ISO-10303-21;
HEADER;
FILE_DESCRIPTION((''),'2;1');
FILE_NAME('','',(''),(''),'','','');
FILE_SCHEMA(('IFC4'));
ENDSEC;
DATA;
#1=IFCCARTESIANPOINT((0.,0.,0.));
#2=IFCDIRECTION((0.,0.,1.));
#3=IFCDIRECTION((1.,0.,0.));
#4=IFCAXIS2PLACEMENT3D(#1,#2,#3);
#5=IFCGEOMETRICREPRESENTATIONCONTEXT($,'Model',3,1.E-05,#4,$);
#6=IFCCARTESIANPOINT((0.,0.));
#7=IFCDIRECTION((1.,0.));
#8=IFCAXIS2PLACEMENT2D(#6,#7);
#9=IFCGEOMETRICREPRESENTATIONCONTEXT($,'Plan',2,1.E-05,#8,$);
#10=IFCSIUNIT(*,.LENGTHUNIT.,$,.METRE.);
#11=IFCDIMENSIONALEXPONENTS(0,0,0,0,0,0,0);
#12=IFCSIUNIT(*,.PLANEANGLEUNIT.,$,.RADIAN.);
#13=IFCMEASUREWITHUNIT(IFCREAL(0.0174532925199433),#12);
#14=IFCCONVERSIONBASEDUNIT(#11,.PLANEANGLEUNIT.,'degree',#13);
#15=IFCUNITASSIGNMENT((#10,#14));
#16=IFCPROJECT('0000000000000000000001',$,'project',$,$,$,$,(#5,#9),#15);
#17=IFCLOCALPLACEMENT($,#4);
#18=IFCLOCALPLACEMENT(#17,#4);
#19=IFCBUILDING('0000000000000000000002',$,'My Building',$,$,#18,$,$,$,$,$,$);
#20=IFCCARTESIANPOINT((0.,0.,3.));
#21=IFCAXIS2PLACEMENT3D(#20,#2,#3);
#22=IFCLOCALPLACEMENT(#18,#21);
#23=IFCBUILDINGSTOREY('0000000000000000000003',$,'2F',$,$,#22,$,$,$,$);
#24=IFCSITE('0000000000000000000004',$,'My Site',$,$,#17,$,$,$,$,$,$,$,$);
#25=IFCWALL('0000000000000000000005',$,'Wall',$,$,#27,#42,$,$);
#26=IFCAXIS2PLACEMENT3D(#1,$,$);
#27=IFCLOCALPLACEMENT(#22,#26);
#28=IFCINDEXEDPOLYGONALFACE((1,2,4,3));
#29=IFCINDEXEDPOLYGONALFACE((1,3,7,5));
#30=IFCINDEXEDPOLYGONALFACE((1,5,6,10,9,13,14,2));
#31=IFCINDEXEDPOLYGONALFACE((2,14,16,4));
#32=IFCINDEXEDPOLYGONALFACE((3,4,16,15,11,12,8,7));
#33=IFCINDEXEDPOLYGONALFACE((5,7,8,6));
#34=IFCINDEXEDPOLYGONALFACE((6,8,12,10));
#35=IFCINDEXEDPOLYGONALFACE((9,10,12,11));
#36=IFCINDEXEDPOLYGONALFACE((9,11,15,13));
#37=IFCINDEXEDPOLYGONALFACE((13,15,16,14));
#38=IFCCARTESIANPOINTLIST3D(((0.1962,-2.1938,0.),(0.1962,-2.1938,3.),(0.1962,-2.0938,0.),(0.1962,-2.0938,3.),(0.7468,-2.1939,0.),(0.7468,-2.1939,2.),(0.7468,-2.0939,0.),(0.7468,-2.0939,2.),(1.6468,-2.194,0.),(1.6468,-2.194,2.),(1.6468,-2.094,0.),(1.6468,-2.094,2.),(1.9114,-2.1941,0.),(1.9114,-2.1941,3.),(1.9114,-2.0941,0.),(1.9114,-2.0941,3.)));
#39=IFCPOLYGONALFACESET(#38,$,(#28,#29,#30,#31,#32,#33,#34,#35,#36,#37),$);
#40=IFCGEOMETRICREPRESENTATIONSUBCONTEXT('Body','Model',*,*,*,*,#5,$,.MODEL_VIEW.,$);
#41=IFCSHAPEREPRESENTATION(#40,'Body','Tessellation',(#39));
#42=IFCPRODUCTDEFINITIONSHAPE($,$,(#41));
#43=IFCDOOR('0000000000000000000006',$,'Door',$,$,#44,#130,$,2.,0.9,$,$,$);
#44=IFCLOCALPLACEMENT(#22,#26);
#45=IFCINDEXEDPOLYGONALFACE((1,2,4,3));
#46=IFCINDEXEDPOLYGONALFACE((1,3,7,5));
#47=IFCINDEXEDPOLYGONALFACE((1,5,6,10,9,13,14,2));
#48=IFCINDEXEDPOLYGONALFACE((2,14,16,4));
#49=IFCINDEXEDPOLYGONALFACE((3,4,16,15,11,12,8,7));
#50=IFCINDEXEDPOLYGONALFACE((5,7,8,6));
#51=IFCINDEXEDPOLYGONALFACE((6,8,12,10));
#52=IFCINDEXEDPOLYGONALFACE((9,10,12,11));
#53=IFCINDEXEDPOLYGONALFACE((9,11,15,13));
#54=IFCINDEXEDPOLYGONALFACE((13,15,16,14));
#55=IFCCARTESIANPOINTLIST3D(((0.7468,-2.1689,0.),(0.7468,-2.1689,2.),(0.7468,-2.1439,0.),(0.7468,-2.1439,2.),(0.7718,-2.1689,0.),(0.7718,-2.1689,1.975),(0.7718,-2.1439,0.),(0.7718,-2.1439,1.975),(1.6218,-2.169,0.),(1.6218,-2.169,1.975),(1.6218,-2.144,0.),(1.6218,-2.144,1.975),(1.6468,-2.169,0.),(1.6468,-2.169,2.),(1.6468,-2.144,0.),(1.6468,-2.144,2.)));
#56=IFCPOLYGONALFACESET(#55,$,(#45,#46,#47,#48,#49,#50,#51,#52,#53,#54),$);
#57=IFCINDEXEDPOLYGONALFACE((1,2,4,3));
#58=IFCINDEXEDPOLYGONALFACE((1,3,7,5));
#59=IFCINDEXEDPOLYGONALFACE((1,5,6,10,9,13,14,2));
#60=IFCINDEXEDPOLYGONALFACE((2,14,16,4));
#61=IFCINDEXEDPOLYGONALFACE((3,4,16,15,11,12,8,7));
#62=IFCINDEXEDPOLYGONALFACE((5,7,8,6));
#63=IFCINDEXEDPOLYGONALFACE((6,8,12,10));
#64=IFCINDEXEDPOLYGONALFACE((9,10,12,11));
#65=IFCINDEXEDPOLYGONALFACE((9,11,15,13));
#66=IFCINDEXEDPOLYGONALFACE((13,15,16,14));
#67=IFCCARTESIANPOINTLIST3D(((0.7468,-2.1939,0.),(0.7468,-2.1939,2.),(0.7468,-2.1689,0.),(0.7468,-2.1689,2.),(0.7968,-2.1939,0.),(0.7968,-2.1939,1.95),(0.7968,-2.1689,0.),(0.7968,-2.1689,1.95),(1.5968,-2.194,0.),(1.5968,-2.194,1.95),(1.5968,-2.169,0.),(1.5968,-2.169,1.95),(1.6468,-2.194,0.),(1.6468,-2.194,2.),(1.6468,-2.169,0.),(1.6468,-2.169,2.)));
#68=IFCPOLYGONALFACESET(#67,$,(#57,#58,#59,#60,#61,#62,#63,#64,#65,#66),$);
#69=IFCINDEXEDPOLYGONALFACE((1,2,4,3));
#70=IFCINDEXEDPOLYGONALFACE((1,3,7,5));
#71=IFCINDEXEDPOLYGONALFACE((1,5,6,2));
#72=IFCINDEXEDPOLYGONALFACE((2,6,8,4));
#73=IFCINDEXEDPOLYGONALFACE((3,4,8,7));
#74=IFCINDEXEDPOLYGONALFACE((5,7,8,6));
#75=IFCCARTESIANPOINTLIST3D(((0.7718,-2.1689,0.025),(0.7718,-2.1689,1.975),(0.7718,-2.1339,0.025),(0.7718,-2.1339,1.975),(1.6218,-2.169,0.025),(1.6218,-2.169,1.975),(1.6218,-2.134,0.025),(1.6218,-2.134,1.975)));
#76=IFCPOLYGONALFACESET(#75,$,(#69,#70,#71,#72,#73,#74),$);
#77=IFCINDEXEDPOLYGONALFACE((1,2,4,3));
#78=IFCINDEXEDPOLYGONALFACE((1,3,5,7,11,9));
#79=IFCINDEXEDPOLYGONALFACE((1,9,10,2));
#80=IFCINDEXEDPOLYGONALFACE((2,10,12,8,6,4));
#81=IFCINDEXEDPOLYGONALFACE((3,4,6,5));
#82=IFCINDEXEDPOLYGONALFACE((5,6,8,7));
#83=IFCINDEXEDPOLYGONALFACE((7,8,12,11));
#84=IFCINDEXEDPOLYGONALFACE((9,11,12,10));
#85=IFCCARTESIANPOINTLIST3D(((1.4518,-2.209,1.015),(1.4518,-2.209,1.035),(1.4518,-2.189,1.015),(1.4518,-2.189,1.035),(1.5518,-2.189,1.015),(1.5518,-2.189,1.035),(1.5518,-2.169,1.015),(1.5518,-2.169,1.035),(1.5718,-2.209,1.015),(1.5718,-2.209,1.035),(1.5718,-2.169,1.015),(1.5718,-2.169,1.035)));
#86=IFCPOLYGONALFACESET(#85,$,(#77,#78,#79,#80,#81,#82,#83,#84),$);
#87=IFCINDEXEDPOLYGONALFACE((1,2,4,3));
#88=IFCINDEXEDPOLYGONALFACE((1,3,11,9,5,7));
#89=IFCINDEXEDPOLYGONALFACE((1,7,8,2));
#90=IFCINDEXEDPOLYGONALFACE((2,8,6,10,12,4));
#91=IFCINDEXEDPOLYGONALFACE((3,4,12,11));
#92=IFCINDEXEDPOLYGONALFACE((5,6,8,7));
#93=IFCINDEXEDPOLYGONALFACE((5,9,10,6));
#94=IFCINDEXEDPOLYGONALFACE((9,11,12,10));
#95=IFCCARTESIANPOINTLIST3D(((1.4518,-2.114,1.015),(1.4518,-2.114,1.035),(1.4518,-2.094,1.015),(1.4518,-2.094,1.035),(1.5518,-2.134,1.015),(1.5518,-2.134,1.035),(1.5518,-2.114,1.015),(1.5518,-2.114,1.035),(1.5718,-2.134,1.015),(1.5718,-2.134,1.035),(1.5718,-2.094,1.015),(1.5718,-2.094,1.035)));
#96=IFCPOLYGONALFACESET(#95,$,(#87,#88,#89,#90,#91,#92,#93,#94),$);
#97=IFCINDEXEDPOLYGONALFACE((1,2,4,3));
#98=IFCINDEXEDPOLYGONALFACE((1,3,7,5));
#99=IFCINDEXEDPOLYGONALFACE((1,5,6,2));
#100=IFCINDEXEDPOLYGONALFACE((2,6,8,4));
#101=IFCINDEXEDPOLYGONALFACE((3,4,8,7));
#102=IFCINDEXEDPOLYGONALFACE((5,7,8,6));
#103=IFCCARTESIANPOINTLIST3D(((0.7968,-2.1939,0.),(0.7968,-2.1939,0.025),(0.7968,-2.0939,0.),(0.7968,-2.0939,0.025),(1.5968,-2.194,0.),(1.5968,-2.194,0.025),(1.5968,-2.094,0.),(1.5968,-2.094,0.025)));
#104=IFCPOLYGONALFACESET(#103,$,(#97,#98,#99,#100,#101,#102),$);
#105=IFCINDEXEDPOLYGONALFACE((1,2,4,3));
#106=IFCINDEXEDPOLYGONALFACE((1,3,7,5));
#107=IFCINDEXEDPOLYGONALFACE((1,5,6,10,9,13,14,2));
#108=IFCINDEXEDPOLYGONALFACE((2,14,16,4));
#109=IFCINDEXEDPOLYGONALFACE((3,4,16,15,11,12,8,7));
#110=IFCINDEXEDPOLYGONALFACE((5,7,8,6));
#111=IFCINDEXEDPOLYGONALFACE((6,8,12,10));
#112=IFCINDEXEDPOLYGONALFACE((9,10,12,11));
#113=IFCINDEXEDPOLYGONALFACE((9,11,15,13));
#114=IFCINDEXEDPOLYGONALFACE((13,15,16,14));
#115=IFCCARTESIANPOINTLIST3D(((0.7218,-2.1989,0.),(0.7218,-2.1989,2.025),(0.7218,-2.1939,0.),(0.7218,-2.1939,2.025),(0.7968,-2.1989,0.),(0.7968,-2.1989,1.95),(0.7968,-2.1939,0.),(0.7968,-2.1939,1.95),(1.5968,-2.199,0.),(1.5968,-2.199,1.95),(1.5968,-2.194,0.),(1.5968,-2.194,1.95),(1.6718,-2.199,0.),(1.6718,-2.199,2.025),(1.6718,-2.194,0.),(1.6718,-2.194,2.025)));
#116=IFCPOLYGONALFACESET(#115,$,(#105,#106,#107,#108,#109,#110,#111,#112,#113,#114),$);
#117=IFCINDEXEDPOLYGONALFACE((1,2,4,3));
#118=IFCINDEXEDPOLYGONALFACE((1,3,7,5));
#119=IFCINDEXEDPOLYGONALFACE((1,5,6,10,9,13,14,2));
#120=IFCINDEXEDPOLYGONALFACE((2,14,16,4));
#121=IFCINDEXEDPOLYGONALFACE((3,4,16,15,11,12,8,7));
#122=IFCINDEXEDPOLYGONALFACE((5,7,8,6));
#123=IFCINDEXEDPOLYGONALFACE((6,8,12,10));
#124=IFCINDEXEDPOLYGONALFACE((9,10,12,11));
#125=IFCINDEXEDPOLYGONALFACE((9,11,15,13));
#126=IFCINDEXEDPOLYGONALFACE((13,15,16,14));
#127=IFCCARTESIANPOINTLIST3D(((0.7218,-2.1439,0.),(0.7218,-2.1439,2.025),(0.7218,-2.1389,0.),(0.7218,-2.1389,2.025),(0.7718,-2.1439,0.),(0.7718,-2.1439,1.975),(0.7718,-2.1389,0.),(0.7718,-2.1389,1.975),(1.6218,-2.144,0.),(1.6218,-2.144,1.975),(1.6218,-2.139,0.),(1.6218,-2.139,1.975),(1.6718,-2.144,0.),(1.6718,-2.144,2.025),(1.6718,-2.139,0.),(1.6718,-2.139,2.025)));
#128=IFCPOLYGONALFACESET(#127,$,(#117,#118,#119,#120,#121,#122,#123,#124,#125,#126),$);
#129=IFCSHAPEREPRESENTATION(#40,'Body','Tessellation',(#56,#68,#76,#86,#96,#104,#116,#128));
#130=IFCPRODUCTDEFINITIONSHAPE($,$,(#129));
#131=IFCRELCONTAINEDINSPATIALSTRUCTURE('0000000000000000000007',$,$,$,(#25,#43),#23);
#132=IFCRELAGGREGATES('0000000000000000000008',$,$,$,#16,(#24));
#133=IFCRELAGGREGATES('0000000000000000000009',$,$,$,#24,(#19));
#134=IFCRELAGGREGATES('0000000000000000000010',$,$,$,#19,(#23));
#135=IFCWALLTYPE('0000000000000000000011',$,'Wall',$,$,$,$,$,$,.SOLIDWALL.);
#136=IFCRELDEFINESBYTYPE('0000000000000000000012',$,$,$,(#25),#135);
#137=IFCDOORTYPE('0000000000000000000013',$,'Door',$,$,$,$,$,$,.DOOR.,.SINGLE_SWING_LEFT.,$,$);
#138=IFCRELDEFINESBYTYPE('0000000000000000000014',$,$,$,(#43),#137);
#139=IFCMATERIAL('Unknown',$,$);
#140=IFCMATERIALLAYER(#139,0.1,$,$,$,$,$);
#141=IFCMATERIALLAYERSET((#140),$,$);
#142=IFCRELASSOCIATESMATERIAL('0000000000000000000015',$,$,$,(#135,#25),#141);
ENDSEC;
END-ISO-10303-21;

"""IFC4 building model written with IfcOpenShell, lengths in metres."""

from ifc_helpers import new_model, entity, si_unit, converted_unit, frame, origin_with_axes, origin_2d_with_axis, place, context, subcontext, project, spatial, line, indexed_curve, outline, extrude, shape, source, transform, mapped, material, layer, layer_set, layer_usage, type_object, type_shapes, element, fill, save


model = new_model("IFC4")

# Units and contexts
model_context = context("Model", 3, precision=1e-05, world=origin_with_axes())
plan_context = context("Plan", 2, precision=1e-05, world=origin_2d_with_axis())
body_context_1 = subcontext(model_context, "Body", "Model", "MODEL_VIEW")
body_context_2 = subcontext(plan_context, "Body", "Plan", "PLAN_VIEW")
ifc_project = project(units=[si_unit("LENGTHUNIT", "METRE"), converted_unit("PLANEANGLEUNIT", "degree", entity("IfcReal", 0.0174532925199433), si_unit("PLANEANGLEUNIT", "RADIAN"), dimensions=[0, 0, 0, 0, 0, 0, 0])], contexts=[model_context, plan_context])

# Site, building, storey
site_placement = place(None, origin_with_axes())
site = spatial("IfcSite", under=ifc_project, at=site_placement, Name="My Site")
building_placement = place(site_placement, origin_with_axes())
building = spatial("IfcBuilding", under=site, at=building_placement, Name="My Building")
storey_placement = place(building_placement, frame((0.0, 0.0, 3.0), z_axis=(0.0, 0.0, 1.0), x_axis=(1.0, 0.0, 0.0)))
storey = spatial("IfcBuildingStorey", under=building, at=storey_placement, Name="2F")

# Shared definitions
ifc_material = material(Name="Unknown")

# Shared definitions
ifc_layer = layer(ifc_material, 0.1)
ifc_layer_set = layer_set([ifc_layer])
wall_type = type_object("IfcWallType", Name="Wall", PredefinedType="SOLIDWALL", material=ifc_layer_set)

# Wall, opening, door
ifc_layer_usage_1 = layer_usage(ifc_layer_set, "AXIS2", "POSITIVE", 0.0)
wall_1_placement = place(storey_placement, frame((0.1962, -2.1938, 0.0), z_axis=(0.0, 0.0, 1.0), x_axis=(1.0, -0.00013, 0.0)))
wall_1 = element("IfcWall", 1, at=wall_1_placement, inside=storey, type_object=wall_type, material=ifc_layer_usage_1, Name="Wall", context=body_context_1, shape_type="SweptSolid", body=[
    extrude(outline(indexed_curve([(0.0, 0.0), (0.0, 0.1), (1.7152, 0.1), (1.7152, 0.0)], segments=[line(1, 2, 3, 4, 1)])), origin_with_axes(), (0.0, 0.0, 1.0), 3.0),
])
shared_shape_1 = source(origin_with_axes(), body_context_1, "Body", "SweptSolid", [
    extrude(outline(indexed_curve([(0.0, 0.0), (0.9, 0.0), (0.9, 2.0), (0.0, 2.0)], segments=[line(1, 2, 3, 4, 1)])), frame((0.0, -0.6, 0.0), z_axis=(0.0, -1.0, 0.0), x_axis=(1.0, 0.0, 0.0)), (0.0, 0.0, -1.0), 1.2),
])
opening_1_placement = place(wall_1_placement, frame((0.5506, 0.0, 0.0), z_axis=(0.0, 0.0, 1.0), x_axis=(1.0, 0.0, 0.0)))
opening_1 = element("IfcOpeningElement", 2, at=opening_1_placement, cuts=wall_1, PredefinedType="OPENING", context=body_context_1, shape_type="MappedRepresentation", body=[
    mapped(shared_shape_1, transform((0.0, 0.0, 0.0), x_axis=(1.0, 0.0, 0.0), y_axis=(0.0, 1.0, 0.0), z_axis=(0.0, 0.0, 1.0), scale=1.0)),
])
door_type = type_object("IfcDoorType", Name="Door", OperationType="SINGLE_SWING_LEFT", PredefinedType="DOOR")
shared_shape_2 = source(origin_with_axes(), body_context_1, "Body", "SweptSolid", [
    extrude(outline(indexed_curve([(0.0, 0.0), (0.0, 2.0), (0.9, 2.0), (0.9, 0.0), (0.875, 0.0), (0.875, 1.975), (0.025, 1.975), (0.025, 0.0)], segments=[line(1, 2, 3, 4, 5, 6, 7, 8, 1)])), frame((0.0, 0.025, 0.0), z_axis=(0.0, -1.0, 0.0), x_axis=(1.0, 0.0, 0.0)), (0.0, 0.0, -1.0), 0.025),
    extrude(outline(indexed_curve([(0.0, 0.0), (0.0, 2.0), (0.9, 2.0), (0.9, 0.0), (0.85, 0.0), (0.85, 1.95), (0.05, 1.95), (0.05, 0.0)], segments=[line(1, 2, 3, 4, 5, 6, 7, 8, 1)])), frame((0.0, 0.0, 0.0), z_axis=(0.0, -1.0, 0.0), x_axis=(1.0, 0.0, 0.0)), (0.0, 0.0, -1.0), 0.025),
    extrude(outline(indexed_curve([(0.0, 0.0), (0.85, 0.0), (0.85, 0.035), (0.0, 0.035)], segments=[line(1, 2, 3, 4, 1)])), frame((0.025, 0.025, 0.025), z_axis=(0.0, 0.0, 1.0), x_axis=(1.0, 0.0, 0.0)), (0.0, 0.0, 1.0), 1.95),
    extrude(outline(indexed_curve([(0.0, 0.0), (0.0, -0.04), (-0.12, -0.04), (-0.12, -0.02), (-0.02, -0.02), (-0.02, 0.0)], segments=[line(1, 2, 3, 4, 5, 6, 1)])), frame((0.825, 0.025, 1.015), z_axis=(0.0, 0.0, 1.0), x_axis=(1.0, 0.0, 0.0)), (0.0, 0.0, 1.0), 0.02),
    extrude(outline(indexed_curve([(0.0, 0.0), (0.0, 0.04), (-0.12, 0.04), (-0.12, 0.02), (-0.02, 0.02), (-0.02, 0.0)], segments=[line(1, 2, 3, 4, 5, 6, 1)])), frame((0.825, 0.06, 1.015), z_axis=(0.0, 0.0, 1.0), x_axis=(1.0, 0.0, 0.0)), (0.0, 0.0, 1.0), 0.02),
    extrude(outline(indexed_curve([(0.0, 0.0), (0.8, 0.0), (0.8, 0.1), (0.0, 0.1)], segments=[line(1, 2, 3, 4, 1)])), frame((0.05, 0.0, 0.0), z_axis=(0.0, 0.0, 1.0), x_axis=(1.0, 0.0, 0.0)), (0.0, 0.0, 1.0), 0.025),
    extrude(outline(indexed_curve([(0.0, 0.0), (0.0, 2.025), (0.95, 2.025), (0.95, 0.0), (0.875, 0.0), (0.875, 1.95), (0.075, 1.95), (0.075, 0.0)], segments=[line(1, 2, 3, 4, 5, 6, 7, 8, 1)])), frame((-0.025, -0.005, 0.0), z_axis=(0.0, -1.0, 0.0), x_axis=(1.0, 0.0, 0.0)), (0.0, 0.0, -1.0), 0.005),
    extrude(outline(indexed_curve([(0.0, 0.0), (0.0, 2.025), (0.95, 2.025), (0.95, 0.0), (0.9, 0.0), (0.9, 1.975), (0.05, 1.975), (0.05, 0.0)], segments=[line(1, 2, 3, 4, 5, 6, 7, 8, 1)])), frame((-0.025, 0.05, 0.0), z_axis=(0.0, -1.0, 0.0), x_axis=(1.0, 0.0, 0.0)), (0.0, 0.0, -1.0), 0.005),
])
shared_shape_3 = source(origin_with_axes(), body_context_2, "Body", "Curve2D", [
    entity("IfcIndexedPolyCurve", entity("IfcCartesianPointList2D", [[0.0, 0.0], [0.0, 0.05], [0.025, 0.05], [0.025, 0.025], [0.05, 0.025], [0.05, 0.0]]), [entity("IfcLineIndex", [1, 2, 3, 4, 5, 6, 1])]),
    entity("IfcIndexedPolyCurve", entity("IfcCartesianPointList2D", [[0.9, 0.0], [0.9, 0.05], [0.875, 0.05], [0.875, 0.025], [0.85, 0.025], [0.85, 0.0]]), [entity("IfcLineIndex", [1, 2, 3, 4, 5, 6, 1])]),
    entity("IfcTrimmedCurve", entity("IfcEllipse", entity("IfcAxis2Placement2D", entity("IfcCartesianPoint", [0.06, 0.05]), entity("IfcDirection", [1.0, 0.0])), 0.815, 0.85), [entity("IfcCartesianPoint", [0.875, 0.05])], [entity("IfcCartesianPoint", [0.06, 0.9])], True, "CARTESIAN"),
    entity("IfcIndexedPolyCurve", entity("IfcCartesianPointList2D", [[0.025, 0.05], [0.06, 0.05], [0.06, 0.9], [0.025, 0.9]]), [entity("IfcLineIndex", [1, 2, 3, 4, 1])]),
])
type_shapes(door_type, [shared_shape_2, shared_shape_3])
door_1_placement = place(opening_1_placement, frame((0.0, 0.0, 0.0), z_axis=(0.0, 0.0, 1.0), x_axis=(1.0, 0.0, 0.0)))
door_1 = element("IfcDoor", 3, at=door_1_placement, inside=storey, type_object=door_type, Name="Door", OverallHeight=2.0, OverallWidth=0.9, shapes=[
    shape(body_context_1, "Body", "MappedRepresentation", [mapped(shared_shape_2, transform((0.0, 0.0, 0.0), x_axis=(1.0, 0.0, 0.0), y_axis=(0.0, 1.0, 0.0), z_axis=(0.0, 0.0, 1.0), scale=1.0))]),
    shape(body_context_2, "Body", "MappedRepresentation", [mapped(shared_shape_3, transform((0.0, 0.0, 0.0), x_axis=(1.0, 0.0, 0.0), y_axis=(0.0, 1.0, 0.0), z_axis=(0.0, 0.0, 1.0), scale=1.0))]),
])
fill(opening_1, door_1)

save(model, "model.ifc")
